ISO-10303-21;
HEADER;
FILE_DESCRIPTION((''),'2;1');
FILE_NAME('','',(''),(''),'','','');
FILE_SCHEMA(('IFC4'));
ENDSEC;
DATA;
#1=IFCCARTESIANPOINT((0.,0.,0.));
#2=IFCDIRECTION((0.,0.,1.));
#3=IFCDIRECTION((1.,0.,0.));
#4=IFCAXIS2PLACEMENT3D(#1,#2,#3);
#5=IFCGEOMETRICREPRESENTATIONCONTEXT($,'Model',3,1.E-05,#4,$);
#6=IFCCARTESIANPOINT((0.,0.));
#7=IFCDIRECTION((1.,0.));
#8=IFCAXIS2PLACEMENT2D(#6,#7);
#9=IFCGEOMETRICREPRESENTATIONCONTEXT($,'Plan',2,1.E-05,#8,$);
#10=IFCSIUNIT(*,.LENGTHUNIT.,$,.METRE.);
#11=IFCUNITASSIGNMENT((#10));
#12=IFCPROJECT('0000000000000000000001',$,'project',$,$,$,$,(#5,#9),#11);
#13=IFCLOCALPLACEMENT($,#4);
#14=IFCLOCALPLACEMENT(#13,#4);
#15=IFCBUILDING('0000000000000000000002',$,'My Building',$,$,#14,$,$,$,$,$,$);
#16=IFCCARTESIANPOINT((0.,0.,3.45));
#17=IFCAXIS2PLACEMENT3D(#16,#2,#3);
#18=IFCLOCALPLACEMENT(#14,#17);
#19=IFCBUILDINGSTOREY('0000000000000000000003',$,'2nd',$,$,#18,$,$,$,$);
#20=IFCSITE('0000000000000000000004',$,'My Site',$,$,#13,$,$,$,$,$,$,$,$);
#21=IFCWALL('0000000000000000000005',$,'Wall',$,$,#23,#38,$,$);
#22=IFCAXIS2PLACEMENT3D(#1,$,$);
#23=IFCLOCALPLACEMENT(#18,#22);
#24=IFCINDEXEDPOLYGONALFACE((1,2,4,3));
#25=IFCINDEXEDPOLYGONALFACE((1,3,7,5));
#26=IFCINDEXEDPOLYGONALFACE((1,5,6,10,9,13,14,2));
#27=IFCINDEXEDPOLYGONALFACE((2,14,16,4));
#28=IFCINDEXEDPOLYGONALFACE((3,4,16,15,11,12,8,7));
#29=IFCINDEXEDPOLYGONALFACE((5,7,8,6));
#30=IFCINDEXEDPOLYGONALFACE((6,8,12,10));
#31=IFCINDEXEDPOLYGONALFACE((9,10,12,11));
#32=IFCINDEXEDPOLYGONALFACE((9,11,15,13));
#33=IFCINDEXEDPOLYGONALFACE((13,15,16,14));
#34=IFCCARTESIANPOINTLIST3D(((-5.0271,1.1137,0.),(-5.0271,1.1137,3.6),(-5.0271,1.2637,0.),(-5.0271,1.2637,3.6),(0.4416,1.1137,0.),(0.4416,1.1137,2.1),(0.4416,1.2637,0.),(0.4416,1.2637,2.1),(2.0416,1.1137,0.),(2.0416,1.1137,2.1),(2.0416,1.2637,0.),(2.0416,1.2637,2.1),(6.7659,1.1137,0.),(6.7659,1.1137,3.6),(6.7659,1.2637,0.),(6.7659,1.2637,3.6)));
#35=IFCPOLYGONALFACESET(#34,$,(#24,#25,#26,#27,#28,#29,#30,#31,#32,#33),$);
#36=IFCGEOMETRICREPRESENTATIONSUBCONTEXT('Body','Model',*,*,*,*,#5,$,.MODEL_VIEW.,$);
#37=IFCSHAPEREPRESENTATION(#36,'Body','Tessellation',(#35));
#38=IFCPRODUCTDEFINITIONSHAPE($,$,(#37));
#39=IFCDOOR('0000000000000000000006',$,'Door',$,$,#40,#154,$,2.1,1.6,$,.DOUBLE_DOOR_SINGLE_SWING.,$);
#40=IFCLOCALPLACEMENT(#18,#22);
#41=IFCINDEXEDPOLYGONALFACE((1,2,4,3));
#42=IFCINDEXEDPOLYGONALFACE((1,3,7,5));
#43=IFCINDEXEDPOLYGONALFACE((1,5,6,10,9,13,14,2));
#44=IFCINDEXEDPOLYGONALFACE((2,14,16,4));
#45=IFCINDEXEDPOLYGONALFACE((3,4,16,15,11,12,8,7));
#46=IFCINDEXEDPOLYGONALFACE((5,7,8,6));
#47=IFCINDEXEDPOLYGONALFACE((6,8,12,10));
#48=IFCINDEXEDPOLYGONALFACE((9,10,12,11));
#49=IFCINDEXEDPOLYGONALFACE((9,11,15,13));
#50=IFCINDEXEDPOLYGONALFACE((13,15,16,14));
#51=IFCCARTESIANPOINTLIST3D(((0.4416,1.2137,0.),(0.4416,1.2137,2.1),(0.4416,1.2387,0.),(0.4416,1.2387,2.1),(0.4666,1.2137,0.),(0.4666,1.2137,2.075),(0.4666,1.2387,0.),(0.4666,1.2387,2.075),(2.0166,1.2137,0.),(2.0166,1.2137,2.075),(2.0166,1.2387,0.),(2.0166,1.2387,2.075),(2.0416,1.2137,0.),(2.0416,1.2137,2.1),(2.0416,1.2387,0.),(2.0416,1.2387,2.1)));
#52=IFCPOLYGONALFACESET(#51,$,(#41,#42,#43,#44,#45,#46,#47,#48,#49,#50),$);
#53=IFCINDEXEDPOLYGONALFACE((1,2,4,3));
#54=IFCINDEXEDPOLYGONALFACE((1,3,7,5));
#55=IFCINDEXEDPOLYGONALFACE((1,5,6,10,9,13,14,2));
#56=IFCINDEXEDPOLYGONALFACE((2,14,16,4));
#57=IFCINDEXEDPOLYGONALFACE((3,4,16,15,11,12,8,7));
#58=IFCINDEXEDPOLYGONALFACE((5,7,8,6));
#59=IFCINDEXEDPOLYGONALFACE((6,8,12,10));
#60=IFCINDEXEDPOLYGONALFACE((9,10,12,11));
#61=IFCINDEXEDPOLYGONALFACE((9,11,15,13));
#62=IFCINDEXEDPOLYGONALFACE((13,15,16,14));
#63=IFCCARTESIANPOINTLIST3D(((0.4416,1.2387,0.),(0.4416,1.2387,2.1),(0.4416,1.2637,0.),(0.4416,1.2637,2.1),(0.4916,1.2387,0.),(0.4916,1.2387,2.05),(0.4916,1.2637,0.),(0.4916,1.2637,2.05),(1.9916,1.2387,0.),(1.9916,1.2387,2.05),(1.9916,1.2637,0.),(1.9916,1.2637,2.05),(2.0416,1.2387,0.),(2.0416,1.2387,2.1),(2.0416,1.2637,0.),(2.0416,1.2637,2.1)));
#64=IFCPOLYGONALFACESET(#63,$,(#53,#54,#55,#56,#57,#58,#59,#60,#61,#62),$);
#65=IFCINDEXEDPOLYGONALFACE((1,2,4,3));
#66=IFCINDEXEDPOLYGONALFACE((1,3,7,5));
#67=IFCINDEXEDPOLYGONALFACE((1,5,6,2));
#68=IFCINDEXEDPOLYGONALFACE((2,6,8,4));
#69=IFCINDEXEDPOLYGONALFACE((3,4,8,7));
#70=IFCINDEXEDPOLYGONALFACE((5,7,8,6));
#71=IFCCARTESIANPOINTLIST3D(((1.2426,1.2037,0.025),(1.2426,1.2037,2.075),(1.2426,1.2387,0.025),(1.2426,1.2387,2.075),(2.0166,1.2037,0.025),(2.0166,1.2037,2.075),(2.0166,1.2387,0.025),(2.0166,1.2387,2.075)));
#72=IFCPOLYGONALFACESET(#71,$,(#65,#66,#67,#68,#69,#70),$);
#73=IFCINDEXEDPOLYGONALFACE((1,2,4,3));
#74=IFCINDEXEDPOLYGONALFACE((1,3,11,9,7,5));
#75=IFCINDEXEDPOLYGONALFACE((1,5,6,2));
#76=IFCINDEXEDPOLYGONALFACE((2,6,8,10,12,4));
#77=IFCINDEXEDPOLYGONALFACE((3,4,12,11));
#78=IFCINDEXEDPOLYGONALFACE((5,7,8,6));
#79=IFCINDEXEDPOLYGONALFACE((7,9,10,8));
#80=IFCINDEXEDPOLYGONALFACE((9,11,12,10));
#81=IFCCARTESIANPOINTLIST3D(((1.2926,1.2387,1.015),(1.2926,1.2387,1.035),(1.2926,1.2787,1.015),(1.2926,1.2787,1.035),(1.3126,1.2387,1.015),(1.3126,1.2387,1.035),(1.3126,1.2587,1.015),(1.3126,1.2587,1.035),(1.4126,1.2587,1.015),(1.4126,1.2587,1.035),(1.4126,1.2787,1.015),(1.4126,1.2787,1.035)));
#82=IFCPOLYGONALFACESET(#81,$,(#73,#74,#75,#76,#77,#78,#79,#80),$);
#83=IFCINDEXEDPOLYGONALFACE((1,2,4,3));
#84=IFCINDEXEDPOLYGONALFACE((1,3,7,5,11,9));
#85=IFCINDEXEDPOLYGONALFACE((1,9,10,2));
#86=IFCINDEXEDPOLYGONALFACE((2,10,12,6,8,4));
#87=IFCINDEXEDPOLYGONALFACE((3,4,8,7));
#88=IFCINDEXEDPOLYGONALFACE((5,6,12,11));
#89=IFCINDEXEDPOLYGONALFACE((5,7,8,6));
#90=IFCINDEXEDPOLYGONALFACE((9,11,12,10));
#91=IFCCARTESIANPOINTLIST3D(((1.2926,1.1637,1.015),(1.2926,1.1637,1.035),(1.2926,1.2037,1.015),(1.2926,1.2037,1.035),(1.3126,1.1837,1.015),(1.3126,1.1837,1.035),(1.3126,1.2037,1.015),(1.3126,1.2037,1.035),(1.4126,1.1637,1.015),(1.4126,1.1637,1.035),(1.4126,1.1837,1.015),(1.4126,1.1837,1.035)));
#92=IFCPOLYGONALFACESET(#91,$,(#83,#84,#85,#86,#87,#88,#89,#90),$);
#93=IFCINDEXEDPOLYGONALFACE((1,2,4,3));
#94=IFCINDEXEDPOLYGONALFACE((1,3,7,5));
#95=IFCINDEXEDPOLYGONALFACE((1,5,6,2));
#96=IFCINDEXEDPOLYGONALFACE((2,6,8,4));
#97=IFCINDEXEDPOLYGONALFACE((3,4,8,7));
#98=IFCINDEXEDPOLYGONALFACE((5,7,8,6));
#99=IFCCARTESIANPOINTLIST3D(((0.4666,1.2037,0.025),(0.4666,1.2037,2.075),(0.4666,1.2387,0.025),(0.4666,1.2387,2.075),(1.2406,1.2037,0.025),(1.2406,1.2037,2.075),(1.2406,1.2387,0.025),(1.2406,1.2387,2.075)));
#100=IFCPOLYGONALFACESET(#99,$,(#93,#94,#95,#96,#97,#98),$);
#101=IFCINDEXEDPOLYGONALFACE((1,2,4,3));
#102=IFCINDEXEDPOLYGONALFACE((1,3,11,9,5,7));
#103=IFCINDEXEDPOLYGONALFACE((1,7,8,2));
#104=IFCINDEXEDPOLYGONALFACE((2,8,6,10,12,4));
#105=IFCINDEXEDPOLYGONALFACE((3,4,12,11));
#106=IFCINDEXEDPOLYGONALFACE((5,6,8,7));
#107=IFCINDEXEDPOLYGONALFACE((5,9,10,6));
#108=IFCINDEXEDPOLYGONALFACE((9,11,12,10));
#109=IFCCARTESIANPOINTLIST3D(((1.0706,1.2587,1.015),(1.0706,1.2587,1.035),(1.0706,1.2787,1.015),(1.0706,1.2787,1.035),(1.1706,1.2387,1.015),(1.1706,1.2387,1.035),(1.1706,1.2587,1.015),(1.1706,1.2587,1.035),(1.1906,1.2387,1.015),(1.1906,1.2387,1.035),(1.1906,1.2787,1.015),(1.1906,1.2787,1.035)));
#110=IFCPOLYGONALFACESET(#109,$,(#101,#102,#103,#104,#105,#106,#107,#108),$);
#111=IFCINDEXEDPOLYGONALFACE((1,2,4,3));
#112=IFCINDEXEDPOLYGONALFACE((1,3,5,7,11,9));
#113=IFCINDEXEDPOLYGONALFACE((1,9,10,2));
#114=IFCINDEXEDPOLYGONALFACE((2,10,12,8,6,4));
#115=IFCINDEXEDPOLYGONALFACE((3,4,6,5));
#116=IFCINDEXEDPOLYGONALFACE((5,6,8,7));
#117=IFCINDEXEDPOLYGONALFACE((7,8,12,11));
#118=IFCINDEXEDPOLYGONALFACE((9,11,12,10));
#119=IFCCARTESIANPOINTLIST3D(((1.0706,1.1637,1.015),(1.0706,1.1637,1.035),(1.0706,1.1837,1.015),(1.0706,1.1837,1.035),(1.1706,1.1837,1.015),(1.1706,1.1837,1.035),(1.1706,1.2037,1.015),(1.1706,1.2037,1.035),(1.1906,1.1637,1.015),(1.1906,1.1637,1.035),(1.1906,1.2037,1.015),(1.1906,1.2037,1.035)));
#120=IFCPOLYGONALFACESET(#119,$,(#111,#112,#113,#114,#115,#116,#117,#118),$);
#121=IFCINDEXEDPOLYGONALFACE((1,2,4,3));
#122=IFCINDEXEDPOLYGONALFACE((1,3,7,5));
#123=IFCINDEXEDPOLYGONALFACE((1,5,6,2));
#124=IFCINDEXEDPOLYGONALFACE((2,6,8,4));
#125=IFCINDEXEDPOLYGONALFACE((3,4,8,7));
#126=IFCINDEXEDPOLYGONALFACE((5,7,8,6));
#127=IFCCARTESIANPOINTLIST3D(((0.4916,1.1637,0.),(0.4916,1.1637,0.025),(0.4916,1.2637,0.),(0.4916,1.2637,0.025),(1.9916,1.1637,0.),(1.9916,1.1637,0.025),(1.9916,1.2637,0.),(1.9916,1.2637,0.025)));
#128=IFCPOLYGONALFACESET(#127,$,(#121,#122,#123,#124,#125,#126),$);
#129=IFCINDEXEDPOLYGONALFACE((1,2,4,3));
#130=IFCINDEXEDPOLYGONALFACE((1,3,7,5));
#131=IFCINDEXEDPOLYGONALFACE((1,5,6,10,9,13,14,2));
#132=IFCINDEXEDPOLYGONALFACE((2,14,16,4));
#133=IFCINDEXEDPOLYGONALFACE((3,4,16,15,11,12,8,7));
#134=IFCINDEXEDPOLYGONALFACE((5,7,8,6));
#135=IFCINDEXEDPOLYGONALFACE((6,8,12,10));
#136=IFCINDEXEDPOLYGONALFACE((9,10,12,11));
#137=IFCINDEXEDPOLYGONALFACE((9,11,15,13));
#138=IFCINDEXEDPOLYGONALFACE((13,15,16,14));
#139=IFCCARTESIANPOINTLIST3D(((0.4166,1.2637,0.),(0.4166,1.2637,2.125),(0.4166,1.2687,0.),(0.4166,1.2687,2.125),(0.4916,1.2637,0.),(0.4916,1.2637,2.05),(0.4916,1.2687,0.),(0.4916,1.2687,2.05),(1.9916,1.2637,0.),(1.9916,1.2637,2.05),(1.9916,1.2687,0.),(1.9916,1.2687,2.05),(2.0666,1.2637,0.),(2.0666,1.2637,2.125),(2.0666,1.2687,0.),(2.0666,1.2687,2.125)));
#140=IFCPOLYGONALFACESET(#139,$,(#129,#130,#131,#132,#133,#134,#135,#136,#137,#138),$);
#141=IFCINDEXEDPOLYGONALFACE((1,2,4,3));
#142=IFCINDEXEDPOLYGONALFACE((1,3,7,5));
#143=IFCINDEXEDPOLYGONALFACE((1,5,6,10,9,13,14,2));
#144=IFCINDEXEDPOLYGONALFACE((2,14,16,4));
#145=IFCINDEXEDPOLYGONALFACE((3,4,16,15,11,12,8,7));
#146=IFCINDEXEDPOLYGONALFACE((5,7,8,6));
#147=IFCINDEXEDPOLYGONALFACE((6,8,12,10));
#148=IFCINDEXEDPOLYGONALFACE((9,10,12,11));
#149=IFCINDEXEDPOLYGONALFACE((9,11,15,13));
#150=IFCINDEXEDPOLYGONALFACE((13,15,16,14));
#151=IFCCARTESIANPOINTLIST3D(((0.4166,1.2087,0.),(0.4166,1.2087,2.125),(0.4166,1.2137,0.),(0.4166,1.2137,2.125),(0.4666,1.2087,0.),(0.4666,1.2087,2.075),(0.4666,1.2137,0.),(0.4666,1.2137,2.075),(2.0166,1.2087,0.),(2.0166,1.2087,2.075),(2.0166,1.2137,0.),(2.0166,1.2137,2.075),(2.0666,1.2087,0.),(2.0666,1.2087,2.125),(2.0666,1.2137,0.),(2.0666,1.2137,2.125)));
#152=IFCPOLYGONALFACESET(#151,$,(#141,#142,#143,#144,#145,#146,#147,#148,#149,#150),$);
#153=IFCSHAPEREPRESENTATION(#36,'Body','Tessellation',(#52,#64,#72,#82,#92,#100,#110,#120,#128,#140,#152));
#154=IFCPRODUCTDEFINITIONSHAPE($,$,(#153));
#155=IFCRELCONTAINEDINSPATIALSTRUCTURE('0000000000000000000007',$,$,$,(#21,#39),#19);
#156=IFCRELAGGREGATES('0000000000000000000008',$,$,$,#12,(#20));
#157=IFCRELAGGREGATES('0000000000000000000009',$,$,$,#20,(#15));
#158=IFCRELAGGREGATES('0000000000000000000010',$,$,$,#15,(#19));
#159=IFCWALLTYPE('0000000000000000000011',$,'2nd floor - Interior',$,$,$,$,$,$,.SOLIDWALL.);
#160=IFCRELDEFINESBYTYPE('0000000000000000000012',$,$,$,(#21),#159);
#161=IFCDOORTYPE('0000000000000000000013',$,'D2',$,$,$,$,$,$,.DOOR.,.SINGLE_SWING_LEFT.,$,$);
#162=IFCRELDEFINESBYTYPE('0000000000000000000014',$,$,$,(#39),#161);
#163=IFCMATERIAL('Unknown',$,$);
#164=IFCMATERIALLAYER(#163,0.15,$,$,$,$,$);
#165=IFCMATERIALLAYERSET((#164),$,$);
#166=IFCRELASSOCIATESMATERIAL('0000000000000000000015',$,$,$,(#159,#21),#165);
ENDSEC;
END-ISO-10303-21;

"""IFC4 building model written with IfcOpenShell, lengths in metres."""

from ifc_helpers import new_model, entity, si_unit, frame, origin_with_axes, origin_2d_with_axis, place, context, subcontext, project, spatial, line, indexed_curve, outline, extrude, shape, source, transform, mapped, material, layer, layer_set, layer_usage, type_object, type_shapes, element, fill, save


model = new_model("IFC4")

# Units and contexts
model_context = context("Model", 3, precision=1e-05, world=origin_with_axes())
plan_context = context("Plan", 2, precision=1e-05, world=origin_2d_with_axis())
body_context_1 = subcontext(model_context, "Body", "Model", "MODEL_VIEW")
body_context_2 = subcontext(plan_context, "Body", "Plan", "PLAN_VIEW")
ifc_project = project(units=[si_unit("LENGTHUNIT", "METRE")], contexts=[model_context, plan_context])

# Site, building, storey
site_placement = place(None, origin_with_axes())
site = spatial("IfcSite", under=ifc_project, at=site_placement, Name="My Site")
building_placement = place(site_placement, origin_with_axes())
building = spatial("IfcBuilding", under=site, at=building_placement, Name="My Building")
storey_placement = place(building_placement, frame((0.0, 0.0, 3.45), z_axis=(0.0, 0.0, 1.0), x_axis=(1.0, 0.0, 0.0)))
storey = spatial("IfcBuildingStorey", under=building, at=storey_placement, Name="2nd")

# Shared definitions
ifc_material = material(Name="Unknown")

# Wall, opening, door
ifc_layer_1 = layer(ifc_material, 0.15)
ifc_layer_set_1 = layer_set([ifc_layer_1])
ifc_layer_usage_1 = layer_usage(ifc_layer_set_1, "AXIS2", "POSITIVE", 0.0)
wall_type_1 = type_object("IfcWallType", Name="2nd floor - Interior", PredefinedType="SOLIDWALL", material=ifc_layer_set_1)
wall_1_placement = place(storey_placement, frame((-5.2271, 1.1137, 0.0), z_axis=(0.0, 0.0, 1.0), x_axis=(1.0, 0.0, 0.0)))
wall_1 = element("IfcWall", 1, at=wall_1_placement, inside=storey, type_object=wall_type_1, material=ifc_layer_usage_1, Name="Wall", context=body_context_1, shape_type="SweptSolid", body=[
    extrude(outline(indexed_curve([(0.2, 0.0), (0.2, 0.15), (11.993, 0.15), (11.993, 0.0)], segments=[line(1, 2, 3, 4, 1)])), origin_with_axes(), (0.0, 0.0, 1.0), 3.6),
])
shared_shape_1 = source(origin_with_axes(), body_context_1, "Body", "SweptSolid", [
    extrude(outline(indexed_curve([(0.0, 0.0), (1.6, 0.0), (1.6, 2.1), (0.0, 2.1)], segments=[line(1, 2, 3, 4, 1)])), frame((0.0, -0.6, 0.0), z_axis=(0.0, -1.0, 0.0), x_axis=(1.0, 0.0, 0.0)), (0.0, 0.0, -1.0), 1.2),
])
opening_1_placement = place(wall_1_placement, frame((7.2688, 0.15, 0.0), z_axis=(0.0, 0.0, 1.0), x_axis=(-1.0, 0.0, 0.0)))
opening_1 = element("IfcOpeningElement", 2, at=opening_1_placement, cuts=wall_1, PredefinedType="OPENING", context=body_context_1, shape_type="MappedRepresentation", body=[
    mapped(shared_shape_1, transform((0.0, 0.0, 0.0), x_axis=(1.0, 0.0, 0.0), y_axis=(0.0, 1.0, 0.0), z_axis=(0.0, 0.0, 1.0), scale=1.0)),
])
door_type_1 = type_object("IfcDoorType", Name="D2", OperationType="SINGLE_SWING_LEFT", PredefinedType="DOOR")
shared_shape_2 = source(origin_with_axes(), body_context_1, "Body", "SweptSolid", [
    extrude(outline(indexed_curve([(0.0, 0.0), (0.0, 2.1), (1.6, 2.1), (1.6, 0.0), (1.575, 0.0), (1.575, 2.075), (0.025, 2.075), (0.025, 0.0)], segments=[line(1, 2, 3, 4, 5, 6, 7, 8, 1)])), frame((0.0, 0.025, 0.0), z_axis=(0.0, -1.0, 0.0), x_axis=(1.0, 0.0, 0.0)), (0.0, 0.0, -1.0), 0.025),
    extrude(outline(indexed_curve([(0.0, 0.0), (0.0, 2.1), (1.6, 2.1), (1.6, 0.0), (1.55, 0.0), (1.55, 2.05), (0.05, 2.05), (0.05, 0.0)], segments=[line(1, 2, 3, 4, 5, 6, 7, 8, 1)])), frame((0.0, 0.0, 0.0), z_axis=(0.0, -1.0, 0.0), x_axis=(1.0, 0.0, 0.0)), (0.0, 0.0, -1.0), 0.025),
    extrude(outline(indexed_curve([(0.0, 0.0), (0.774, 0.0), (0.774, 0.035), (0.0, 0.035)], segments=[line(1, 2, 3, 4, 1)])), frame((0.025, 0.025, 0.025), z_axis=(0.0, 0.0, 1.0), x_axis=(1.0, 0.0, 0.0)), (0.0, 0.0, 1.0), 2.05),
    extrude(outline(indexed_curve([(0.0, 0.0), (0.0, -0.04), (-0.12, -0.04), (-0.12, -0.02), (-0.02, -0.02), (-0.02, 0.0)], segments=[line(1, 2, 3, 4, 5, 6, 1)])), frame((0.749, 0.025, 1.015), z_axis=(0.0, 0.0, 1.0), x_axis=(1.0, 0.0, 0.0)), (0.0, 0.0, 1.0), 0.02),
    extrude(outline(indexed_curve([(0.0, 0.0), (0.0, 0.04), (-0.12, 0.04), (-0.12, 0.02), (-0.02, 0.02), (-0.02, 0.0)], segments=[line(1, 2, 3, 4, 5, 6, 1)])), frame((0.749, 0.06, 1.015), z_axis=(0.0, 0.0, 1.0), x_axis=(1.0, 0.0, 0.0)), (0.0, 0.0, 1.0), 0.02),
    extrude(outline(indexed_curve([(0.0, 0.0), (-0.774, 0.0), (-0.774, 0.035), (0.0, 0.035)], segments=[line(1, 2, 3, 4, 1)])), frame((1.575, 0.025, 0.025), z_axis=(0.0, 0.0, 1.0), x_axis=(1.0, 0.0, 0.0)), (0.0, 0.0, 1.0), 2.05),
    extrude(outline(indexed_curve([(0.0, 0.0), (0.0, -0.04), (0.12, -0.04), (0.12, -0.02), (0.02, -0.02), (0.02, 0.0)], segments=[line(1, 2, 3, 4, 5, 6, 1)])), frame((0.851, 0.025, 1.015), z_axis=(0.0, 0.0, 1.0), x_axis=(1.0, 0.0, 0.0)), (0.0, 0.0, 1.0), 0.02),
    extrude(outline(indexed_curve([(0.0, 0.0), (0.0, 0.04), (0.12, 0.04), (0.12, 0.02), (0.02, 0.02), (0.02, 0.0)], segments=[line(1, 2, 3, 4, 5, 6, 1)])), frame((0.851, 0.06, 1.015), z_axis=(0.0, 0.0, 1.0), x_axis=(1.0, 0.0, 0.0)), (0.0, 0.0, 1.0), 0.02),
    extrude(outline(indexed_curve([(0.0, 0.0), (1.5, 0.0), (1.5, 0.1), (0.0, 0.1)], segments=[line(1, 2, 3, 4, 1)])), frame((0.05, 0.0, 0.0), z_axis=(0.0, 0.0, 1.0), x_axis=(1.0, 0.0, 0.0)), (0.0, 0.0, 1.0), 0.025),
    extrude(outline(indexed_curve([(0.0, 0.0), (0.0, 2.125), (1.65, 2.125), (1.65, 0.0), (1.575, 0.0), (1.575, 2.05), (0.075, 2.05), (0.075, 0.0)], segments=[line(1, 2, 3, 4, 5, 6, 7, 8, 1)])), frame((-0.025, -0.005, 0.0), z_axis=(0.0, -1.0, 0.0), x_axis=(1.0, 0.0, 0.0)), (0.0, 0.0, -1.0), 0.005),
    extrude(outline(indexed_curve([(0.0, 0.0), (0.0, 2.125), (1.65, 2.125), (1.65, 0.0), (1.6, 0.0), (1.6, 2.075), (0.05, 2.075), (0.05, 0.0)], segments=[line(1, 2, 3, 4, 5, 6, 7, 8, 1)])), frame((-0.025, 0.05, 0.0), z_axis=(0.0, -1.0, 0.0), x_axis=(1.0, 0.0, 0.0)), (0.0, 0.0, -1.0), 0.005),
])
shared_shape_3 = source(origin_with_axes(), body_context_2, "Body", "Curve2D", [
    entity("IfcIndexedPolyCurve", entity("IfcCartesianPointList2D", [[0.0, 0.0], [0.0, 0.05], [0.025, 0.05], [0.025, 0.025], [0.05, 0.025], [0.05, 0.0]]), [entity("IfcLineIndex", [1, 2, 3, 4, 5, 6, 1])]),
    entity("IfcIndexedPolyCurve", entity("IfcCartesianPointList2D", [[1.6, 0.0], [1.6, 0.05], [1.575, 0.05], [1.575, 0.025], [1.55, 0.025], [1.55, 0.0]]), [entity("IfcLineIndex", [1, 2, 3, 4, 5, 6, 1])]),
    entity("IfcTrimmedCurve", entity("IfcEllipse", entity("IfcAxis2Placement2D", entity("IfcCartesianPoint", [0.06, 0.05]), entity("IfcDirection", [1.0, 0.0])), 0.74, 0.775), [entity("IfcCartesianPoint", [0.8, 0.05])], [entity("IfcCartesianPoint", [0.06, 0.825])], True, "CARTESIAN"),
    entity("IfcIndexedPolyCurve", entity("IfcCartesianPointList2D", [[0.025, 0.05], [0.06, 0.05], [0.06, 0.825], [0.025, 0.825]]), [entity("IfcLineIndex", [1, 2, 3, 4, 1])]),
    entity("IfcTrimmedCurve", entity("IfcEllipse", entity("IfcAxis2Placement2D", entity("IfcCartesianPoint", [1.54, 0.05]), entity("IfcDirection", [1.0, 0.0])), 0.74, 0.775), [entity("IfcCartesianPoint", [1.54, 0.825])], [entity("IfcCartesianPoint", [0.8, 0.05])], True, "CARTESIAN"),
    entity("IfcIndexedPolyCurve", entity("IfcCartesianPointList2D", [[1.575, 0.05], [1.54, 0.05], [1.54, 0.825], [1.575, 0.825]]), [entity("IfcLineIndex", [1, 2, 3, 4, 1])]),
])
type_shapes(door_type_1, [shared_shape_2, shared_shape_3])
door_1_placement = place(opening_1_placement, origin_with_axes())
door_1 = element("IfcDoor", 3, at=door_1_placement, inside=storey, type_object=door_type_1, Name="Door", OperationType="DOUBLE_DOOR_SINGLE_SWING", OverallHeight=2.1, OverallWidth=1.6, shapes=[
    shape(body_context_1, "Body", "MappedRepresentation", [mapped(shared_shape_2, transform((0.0, 0.0, 0.0), x_axis=(1.0, 0.0, 0.0), y_axis=(0.0, 1.0, 0.0), z_axis=(0.0, 0.0, 1.0), scale=1.0))]),
    shape(body_context_2, "Body", "MappedRepresentation", [mapped(shared_shape_3, transform((0.0, 0.0, 0.0), x_axis=(1.0, 0.0, 0.0), y_axis=(0.0, 1.0, 0.0), z_axis=(0.0, 0.0, 1.0), scale=1.0))]),
])
fill(opening_1, door_1)

save(model, "model.ifc")
